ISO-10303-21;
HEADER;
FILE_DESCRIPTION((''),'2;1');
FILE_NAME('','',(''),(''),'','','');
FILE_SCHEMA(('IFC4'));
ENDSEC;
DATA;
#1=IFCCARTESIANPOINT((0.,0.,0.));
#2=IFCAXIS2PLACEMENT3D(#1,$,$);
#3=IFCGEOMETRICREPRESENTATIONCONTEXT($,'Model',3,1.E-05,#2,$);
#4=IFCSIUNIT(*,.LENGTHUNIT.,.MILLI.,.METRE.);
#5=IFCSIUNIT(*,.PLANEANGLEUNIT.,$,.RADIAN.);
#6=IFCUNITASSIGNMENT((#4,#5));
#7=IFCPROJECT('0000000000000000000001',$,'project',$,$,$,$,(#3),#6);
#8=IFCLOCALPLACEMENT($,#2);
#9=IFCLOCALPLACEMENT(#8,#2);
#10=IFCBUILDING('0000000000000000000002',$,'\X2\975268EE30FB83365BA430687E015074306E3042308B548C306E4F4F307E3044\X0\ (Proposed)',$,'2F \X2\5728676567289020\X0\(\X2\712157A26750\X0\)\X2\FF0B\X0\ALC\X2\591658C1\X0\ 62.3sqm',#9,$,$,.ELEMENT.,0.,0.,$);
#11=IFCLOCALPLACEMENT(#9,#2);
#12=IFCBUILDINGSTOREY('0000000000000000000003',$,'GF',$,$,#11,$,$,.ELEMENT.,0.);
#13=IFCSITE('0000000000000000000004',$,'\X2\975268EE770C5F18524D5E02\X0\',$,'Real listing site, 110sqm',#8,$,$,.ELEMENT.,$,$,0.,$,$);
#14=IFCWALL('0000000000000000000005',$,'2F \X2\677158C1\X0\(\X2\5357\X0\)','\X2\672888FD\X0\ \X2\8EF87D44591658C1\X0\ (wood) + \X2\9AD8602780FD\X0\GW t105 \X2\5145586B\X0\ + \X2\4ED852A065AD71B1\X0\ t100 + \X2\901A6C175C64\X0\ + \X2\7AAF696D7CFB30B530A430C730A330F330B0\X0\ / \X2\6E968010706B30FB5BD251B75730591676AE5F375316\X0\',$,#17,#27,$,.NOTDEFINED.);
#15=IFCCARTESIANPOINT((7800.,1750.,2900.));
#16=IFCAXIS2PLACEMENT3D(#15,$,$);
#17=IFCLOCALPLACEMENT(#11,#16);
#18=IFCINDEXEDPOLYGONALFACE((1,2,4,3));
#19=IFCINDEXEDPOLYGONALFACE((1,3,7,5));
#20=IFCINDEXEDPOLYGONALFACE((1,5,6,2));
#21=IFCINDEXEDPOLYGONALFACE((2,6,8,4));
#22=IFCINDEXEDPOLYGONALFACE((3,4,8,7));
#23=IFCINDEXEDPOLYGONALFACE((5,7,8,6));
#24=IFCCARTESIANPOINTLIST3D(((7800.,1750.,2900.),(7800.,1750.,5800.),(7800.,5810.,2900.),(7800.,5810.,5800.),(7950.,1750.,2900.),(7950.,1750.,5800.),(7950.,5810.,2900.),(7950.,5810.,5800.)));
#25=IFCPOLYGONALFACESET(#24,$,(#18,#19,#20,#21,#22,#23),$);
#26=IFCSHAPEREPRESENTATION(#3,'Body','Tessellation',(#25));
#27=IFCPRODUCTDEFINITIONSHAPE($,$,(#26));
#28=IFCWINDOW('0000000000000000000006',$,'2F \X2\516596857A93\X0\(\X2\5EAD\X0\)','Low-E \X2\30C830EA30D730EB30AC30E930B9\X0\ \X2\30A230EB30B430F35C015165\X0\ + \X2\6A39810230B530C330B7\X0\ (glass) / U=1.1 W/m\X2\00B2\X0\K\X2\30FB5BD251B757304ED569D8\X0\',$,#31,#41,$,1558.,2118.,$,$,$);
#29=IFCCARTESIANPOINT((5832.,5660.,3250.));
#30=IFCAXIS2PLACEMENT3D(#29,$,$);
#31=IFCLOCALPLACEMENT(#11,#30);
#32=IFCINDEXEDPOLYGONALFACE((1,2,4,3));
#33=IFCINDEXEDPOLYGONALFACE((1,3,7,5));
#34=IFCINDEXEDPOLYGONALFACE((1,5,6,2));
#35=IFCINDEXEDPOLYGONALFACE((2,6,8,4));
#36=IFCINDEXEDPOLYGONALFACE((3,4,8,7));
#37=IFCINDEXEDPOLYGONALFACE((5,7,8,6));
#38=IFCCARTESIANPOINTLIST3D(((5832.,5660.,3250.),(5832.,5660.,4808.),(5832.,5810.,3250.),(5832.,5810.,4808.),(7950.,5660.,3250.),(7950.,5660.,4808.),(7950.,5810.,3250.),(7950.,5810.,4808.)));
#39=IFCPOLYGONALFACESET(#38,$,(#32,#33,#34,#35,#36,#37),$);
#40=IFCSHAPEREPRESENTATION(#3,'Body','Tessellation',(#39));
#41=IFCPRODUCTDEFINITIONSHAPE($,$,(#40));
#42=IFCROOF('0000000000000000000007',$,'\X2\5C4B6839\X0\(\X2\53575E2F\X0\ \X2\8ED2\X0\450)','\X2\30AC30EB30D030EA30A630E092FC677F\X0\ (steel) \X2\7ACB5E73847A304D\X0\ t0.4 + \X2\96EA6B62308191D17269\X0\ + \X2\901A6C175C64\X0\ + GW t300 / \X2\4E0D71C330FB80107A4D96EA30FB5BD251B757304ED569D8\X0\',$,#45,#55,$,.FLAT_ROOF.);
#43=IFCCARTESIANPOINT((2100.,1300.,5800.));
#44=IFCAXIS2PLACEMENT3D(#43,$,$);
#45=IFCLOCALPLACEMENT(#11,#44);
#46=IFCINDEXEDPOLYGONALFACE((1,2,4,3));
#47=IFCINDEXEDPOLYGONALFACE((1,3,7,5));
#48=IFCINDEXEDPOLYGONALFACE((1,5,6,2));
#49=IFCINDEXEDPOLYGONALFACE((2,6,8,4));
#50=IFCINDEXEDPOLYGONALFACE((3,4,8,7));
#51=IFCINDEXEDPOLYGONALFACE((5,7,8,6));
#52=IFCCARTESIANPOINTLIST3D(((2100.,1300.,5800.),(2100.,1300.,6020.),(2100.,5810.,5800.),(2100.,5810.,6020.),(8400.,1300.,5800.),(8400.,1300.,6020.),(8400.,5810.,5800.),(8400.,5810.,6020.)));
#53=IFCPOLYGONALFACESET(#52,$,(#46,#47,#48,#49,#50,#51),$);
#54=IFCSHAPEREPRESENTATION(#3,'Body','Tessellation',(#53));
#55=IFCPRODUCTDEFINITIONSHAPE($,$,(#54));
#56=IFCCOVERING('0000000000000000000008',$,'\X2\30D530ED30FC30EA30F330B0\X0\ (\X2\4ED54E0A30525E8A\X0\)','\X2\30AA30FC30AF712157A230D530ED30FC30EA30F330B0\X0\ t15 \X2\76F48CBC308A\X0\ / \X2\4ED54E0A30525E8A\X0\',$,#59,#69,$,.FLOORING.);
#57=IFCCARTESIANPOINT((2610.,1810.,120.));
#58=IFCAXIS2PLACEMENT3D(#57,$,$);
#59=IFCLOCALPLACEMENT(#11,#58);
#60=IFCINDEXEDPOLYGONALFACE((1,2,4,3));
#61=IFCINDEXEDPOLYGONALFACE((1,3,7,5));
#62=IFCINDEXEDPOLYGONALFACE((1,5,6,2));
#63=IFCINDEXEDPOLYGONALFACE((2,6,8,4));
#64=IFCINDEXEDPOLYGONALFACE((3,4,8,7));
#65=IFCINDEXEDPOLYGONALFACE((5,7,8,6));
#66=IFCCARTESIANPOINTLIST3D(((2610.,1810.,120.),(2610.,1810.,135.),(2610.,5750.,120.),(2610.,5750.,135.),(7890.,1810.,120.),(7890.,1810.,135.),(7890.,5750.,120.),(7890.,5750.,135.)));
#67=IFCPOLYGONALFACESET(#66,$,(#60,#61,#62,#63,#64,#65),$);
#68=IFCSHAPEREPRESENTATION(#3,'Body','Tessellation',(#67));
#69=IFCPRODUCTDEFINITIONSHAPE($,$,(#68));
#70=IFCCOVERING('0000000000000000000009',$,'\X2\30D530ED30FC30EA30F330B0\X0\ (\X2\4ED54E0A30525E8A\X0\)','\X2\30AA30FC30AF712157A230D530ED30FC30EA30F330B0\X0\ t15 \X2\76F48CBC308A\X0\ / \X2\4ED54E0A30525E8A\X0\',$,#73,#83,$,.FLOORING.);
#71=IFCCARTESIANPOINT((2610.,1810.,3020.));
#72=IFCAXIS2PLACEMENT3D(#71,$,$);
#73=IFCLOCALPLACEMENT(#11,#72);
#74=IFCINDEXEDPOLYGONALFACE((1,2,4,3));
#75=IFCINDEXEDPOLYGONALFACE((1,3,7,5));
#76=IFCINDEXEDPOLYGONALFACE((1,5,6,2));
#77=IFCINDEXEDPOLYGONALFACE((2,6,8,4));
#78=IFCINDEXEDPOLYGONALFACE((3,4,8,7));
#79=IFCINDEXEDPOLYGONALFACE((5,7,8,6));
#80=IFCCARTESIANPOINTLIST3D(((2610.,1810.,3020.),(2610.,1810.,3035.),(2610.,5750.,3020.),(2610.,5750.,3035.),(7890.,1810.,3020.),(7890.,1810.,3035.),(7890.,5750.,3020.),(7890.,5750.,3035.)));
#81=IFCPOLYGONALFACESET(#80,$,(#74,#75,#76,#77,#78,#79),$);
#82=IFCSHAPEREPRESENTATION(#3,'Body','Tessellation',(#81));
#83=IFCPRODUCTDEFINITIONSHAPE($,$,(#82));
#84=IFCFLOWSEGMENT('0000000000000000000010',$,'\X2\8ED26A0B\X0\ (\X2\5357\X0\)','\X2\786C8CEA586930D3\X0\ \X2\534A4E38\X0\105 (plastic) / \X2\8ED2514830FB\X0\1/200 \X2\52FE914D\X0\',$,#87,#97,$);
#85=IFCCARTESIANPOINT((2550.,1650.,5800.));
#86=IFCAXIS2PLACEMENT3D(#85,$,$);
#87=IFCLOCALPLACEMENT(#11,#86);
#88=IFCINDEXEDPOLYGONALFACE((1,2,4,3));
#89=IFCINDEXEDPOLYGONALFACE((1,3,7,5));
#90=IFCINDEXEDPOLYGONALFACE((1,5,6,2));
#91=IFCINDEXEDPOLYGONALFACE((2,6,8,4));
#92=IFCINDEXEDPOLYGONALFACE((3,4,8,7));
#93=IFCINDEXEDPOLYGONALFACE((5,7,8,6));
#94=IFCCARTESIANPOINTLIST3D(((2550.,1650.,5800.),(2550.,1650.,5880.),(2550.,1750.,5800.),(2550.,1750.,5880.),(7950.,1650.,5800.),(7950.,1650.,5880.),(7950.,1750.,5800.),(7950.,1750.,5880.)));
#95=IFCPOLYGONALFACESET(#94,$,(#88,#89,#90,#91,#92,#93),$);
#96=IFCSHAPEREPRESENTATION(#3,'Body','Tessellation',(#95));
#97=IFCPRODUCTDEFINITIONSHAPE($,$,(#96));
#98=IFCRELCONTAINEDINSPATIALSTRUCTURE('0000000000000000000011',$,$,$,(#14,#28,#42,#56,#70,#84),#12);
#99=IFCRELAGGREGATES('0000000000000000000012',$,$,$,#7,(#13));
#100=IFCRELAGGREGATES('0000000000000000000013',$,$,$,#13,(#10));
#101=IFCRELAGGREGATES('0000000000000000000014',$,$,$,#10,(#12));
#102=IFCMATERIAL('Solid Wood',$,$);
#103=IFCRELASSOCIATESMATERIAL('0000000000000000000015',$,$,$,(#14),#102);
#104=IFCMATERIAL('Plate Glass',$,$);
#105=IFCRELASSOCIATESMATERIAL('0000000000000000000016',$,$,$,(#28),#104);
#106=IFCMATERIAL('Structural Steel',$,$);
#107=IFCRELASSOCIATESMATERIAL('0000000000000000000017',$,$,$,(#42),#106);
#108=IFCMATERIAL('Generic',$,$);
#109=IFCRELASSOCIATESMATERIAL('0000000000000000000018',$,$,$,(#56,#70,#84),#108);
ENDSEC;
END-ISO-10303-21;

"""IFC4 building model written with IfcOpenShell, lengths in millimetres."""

from ifc_helpers import new_model, si_unit, frame, frame_2d, origin, place, context, project, spatial, rectangle, extrude, material, element, fill, save


model = new_model("IFC4")

# Units and contexts
model_context = context("Model", 3, precision=1e-05, world=origin())
ifc_project = project(units=[si_unit("LENGTHUNIT", "METRE", prefix="MILLI"), si_unit("PLANEANGLEUNIT", "RADIAN")], contexts=[model_context])

# Site, building, storey
site_placement = place(None, origin())
site = spatial("IfcSite", under=ifc_project, at=site_placement, Name="青森県弘前市", ObjectType="Real listing site, 110sqm", CompositionType="ELEMENT", RefElevation=0.0)
building_placement = place(site_placement, origin())
building = spatial("IfcBuilding", under=site, at=building_placement, Name="青森・茶室と縁側のある和の住まい (Proposed)", ObjectType="2F 在来木造(無垢材)＋ALC外壁 62.3sqm", CompositionType="ELEMENT", ElevationOfRefHeight=0.0, ElevationOfTerrain=0.0)
storey_placement = place(building_placement, origin())
storey = spatial("IfcBuildingStorey", under=building, at=storey_placement, Name="GF", CompositionType="ELEMENT", Elevation=0.0)

# Shared definitions
ifc_material_1 = material(Name="Solid Wood")

# Wall, opening, window
ifc_material_2 = material(Name="Plate Glass")
wall_1_placement = place(storey_placement, frame((7800.0, 1750.0, 2900.0)))
wall_1 = element("IfcWall", 1, at=wall_1_placement, inside=storey, material=ifc_material_1, Name="2F 東壁(南)", Description="木製 軸組外壁 (wood) + 高性能GW t105 充填 + 付加断熱 t100 + 通気層 + 窯業系サイディング / 準耐火・寒冷地外皮強化", PredefinedType="NOTDEFINED", context=model_context, shape_type="SweptSolid", body=[
    extrude(rectangle(XDim=150.0, YDim=4060.0, at=frame_2d((75.0, 2030.0))), frame((7800.0, 1750.0, 2900.0)), (0.0, 0.0, 1.0), 2900.0),
])
opening_1_placement = place(storey_placement, frame((5832.0, 5660.0, 3250.0)))
opening_1 = element("IfcOpeningElement", 2, at=opening_1_placement, cuts=wall_1, PredefinedType="NOTDEFINED", context=model_context, shape_type="SweptSolid", body=[
    extrude(rectangle(XDim=2118.0, YDim=150.0, at=frame_2d((1059.0, 75.0))), frame((5832.0, 5660.0, 3250.0)), (0.0, 0.0, 1.0), 1558.0),
])
window_1_placement = place(storey_placement, frame((5832.0, 5660.0, 3250.0)))
window_1 = element("IfcWindow", 3, at=window_1_placement, inside=storey, material=ifc_material_2, Name="2F 入隅窓(庭)", Description="Low-E トリプルガラス アルゴン封入 + 樹脂サッシ (glass) / U=1.1 W/m²K・寒冷地仕様", OverallHeight=1558.0, OverallWidth=2118.0, context=model_context, shape_type="SweptSolid", body=[
    extrude(rectangle(XDim=2118.0, YDim=150.0, at=frame_2d((1059.0, 75.0))), frame((5832.0, 5660.0, 3250.0)), (0.0, 0.0, 1.0), 1558.0),
])
fill(opening_1, window_1)

# Roof
ifc_material_3 = material(Name="Structural Steel")
for number, where, name in (
    (4, (2100.0, 1300.0, 5800.0), "屋根(南帯 軒450)"),
):
    element("IfcRoof", number, at=place(storey_placement, frame(where)), inside=storey, material=ifc_material_3, Name=name, Description="ガルバリウム鋼板 (steel) 立平葺き t0.4 + 雪止め金物 + 通気層 + GW t300 / 不燃・耐積雪・寒冷地仕様", PredefinedType="FLAT_ROOF", context=model_context, shape_type="SweptSolid", body=[
        extrude(rectangle(XDim=6300.0, YDim=4510.0, at=frame_2d((3150.0, 2255.0))), frame((2100.0, 1300.0, 5800.0)), (0.0, 0.0, 1.0), 220.0),
    ])

# Coverings
ifc_material_4 = material(Name="Generic")
covering_1_placement = place(storey_placement, frame((2610.0, 1810.0, 120.0)))
element("IfcCovering", 5, at=covering_1_placement, inside=storey, material=ifc_material_4, Name="フローリング (仕上げ床)", Description="オーク無垢フローリング t15 直貼り / 仕上げ床", PredefinedType="FLOORING", context=model_context, shape_type="SweptSolid", body=[
    extrude(rectangle(XDim=5280.0, YDim=3940.0, at=frame_2d((2640.0, 1970.0))), frame((2610.0, 1810.0, 120.0)), (0.0, 0.0, 1.0), 15.0),
])
covering_2_placement = place(storey_placement, frame((2610.0, 1810.0, 3020.0)))
element("IfcCovering", 6, at=covering_2_placement, inside=storey, material=ifc_material_4, Name="フローリング (仕上げ床)", Description="オーク無垢フローリング t15 直貼り / 仕上げ床", PredefinedType="FLOORING", context=model_context, shape_type="SweptSolid", body=[
    extrude(rectangle(XDim=5280.0, YDim=3940.0, at=frame_2d((2640.0, 1970.0))), frame((2610.0, 1810.0, 3020.0)), (0.0, 0.0, 1.0), 15.0),
])

# Flow segment
flow_segment_placement = place(storey_placement, frame((2550.0, 1650.0, 5800.0)))
element("IfcFlowSegment", 7, at=flow_segment_placement, inside=storey, material=ifc_material_4, Name="軒樋 (南)", Description="硬質塩ビ 半丸105 (plastic) / 軒先・1/200 勾配", context=model_context, shape_type="SweptSolid", body=[
    extrude(rectangle(XDim=5400.0, YDim=100.0, at=frame_2d((2700.0, 50.0))), frame((2550.0, 1650.0, 5800.0)), (0.0, 0.0, 1.0), 80.0),
])

save(model, "model.ifc")
